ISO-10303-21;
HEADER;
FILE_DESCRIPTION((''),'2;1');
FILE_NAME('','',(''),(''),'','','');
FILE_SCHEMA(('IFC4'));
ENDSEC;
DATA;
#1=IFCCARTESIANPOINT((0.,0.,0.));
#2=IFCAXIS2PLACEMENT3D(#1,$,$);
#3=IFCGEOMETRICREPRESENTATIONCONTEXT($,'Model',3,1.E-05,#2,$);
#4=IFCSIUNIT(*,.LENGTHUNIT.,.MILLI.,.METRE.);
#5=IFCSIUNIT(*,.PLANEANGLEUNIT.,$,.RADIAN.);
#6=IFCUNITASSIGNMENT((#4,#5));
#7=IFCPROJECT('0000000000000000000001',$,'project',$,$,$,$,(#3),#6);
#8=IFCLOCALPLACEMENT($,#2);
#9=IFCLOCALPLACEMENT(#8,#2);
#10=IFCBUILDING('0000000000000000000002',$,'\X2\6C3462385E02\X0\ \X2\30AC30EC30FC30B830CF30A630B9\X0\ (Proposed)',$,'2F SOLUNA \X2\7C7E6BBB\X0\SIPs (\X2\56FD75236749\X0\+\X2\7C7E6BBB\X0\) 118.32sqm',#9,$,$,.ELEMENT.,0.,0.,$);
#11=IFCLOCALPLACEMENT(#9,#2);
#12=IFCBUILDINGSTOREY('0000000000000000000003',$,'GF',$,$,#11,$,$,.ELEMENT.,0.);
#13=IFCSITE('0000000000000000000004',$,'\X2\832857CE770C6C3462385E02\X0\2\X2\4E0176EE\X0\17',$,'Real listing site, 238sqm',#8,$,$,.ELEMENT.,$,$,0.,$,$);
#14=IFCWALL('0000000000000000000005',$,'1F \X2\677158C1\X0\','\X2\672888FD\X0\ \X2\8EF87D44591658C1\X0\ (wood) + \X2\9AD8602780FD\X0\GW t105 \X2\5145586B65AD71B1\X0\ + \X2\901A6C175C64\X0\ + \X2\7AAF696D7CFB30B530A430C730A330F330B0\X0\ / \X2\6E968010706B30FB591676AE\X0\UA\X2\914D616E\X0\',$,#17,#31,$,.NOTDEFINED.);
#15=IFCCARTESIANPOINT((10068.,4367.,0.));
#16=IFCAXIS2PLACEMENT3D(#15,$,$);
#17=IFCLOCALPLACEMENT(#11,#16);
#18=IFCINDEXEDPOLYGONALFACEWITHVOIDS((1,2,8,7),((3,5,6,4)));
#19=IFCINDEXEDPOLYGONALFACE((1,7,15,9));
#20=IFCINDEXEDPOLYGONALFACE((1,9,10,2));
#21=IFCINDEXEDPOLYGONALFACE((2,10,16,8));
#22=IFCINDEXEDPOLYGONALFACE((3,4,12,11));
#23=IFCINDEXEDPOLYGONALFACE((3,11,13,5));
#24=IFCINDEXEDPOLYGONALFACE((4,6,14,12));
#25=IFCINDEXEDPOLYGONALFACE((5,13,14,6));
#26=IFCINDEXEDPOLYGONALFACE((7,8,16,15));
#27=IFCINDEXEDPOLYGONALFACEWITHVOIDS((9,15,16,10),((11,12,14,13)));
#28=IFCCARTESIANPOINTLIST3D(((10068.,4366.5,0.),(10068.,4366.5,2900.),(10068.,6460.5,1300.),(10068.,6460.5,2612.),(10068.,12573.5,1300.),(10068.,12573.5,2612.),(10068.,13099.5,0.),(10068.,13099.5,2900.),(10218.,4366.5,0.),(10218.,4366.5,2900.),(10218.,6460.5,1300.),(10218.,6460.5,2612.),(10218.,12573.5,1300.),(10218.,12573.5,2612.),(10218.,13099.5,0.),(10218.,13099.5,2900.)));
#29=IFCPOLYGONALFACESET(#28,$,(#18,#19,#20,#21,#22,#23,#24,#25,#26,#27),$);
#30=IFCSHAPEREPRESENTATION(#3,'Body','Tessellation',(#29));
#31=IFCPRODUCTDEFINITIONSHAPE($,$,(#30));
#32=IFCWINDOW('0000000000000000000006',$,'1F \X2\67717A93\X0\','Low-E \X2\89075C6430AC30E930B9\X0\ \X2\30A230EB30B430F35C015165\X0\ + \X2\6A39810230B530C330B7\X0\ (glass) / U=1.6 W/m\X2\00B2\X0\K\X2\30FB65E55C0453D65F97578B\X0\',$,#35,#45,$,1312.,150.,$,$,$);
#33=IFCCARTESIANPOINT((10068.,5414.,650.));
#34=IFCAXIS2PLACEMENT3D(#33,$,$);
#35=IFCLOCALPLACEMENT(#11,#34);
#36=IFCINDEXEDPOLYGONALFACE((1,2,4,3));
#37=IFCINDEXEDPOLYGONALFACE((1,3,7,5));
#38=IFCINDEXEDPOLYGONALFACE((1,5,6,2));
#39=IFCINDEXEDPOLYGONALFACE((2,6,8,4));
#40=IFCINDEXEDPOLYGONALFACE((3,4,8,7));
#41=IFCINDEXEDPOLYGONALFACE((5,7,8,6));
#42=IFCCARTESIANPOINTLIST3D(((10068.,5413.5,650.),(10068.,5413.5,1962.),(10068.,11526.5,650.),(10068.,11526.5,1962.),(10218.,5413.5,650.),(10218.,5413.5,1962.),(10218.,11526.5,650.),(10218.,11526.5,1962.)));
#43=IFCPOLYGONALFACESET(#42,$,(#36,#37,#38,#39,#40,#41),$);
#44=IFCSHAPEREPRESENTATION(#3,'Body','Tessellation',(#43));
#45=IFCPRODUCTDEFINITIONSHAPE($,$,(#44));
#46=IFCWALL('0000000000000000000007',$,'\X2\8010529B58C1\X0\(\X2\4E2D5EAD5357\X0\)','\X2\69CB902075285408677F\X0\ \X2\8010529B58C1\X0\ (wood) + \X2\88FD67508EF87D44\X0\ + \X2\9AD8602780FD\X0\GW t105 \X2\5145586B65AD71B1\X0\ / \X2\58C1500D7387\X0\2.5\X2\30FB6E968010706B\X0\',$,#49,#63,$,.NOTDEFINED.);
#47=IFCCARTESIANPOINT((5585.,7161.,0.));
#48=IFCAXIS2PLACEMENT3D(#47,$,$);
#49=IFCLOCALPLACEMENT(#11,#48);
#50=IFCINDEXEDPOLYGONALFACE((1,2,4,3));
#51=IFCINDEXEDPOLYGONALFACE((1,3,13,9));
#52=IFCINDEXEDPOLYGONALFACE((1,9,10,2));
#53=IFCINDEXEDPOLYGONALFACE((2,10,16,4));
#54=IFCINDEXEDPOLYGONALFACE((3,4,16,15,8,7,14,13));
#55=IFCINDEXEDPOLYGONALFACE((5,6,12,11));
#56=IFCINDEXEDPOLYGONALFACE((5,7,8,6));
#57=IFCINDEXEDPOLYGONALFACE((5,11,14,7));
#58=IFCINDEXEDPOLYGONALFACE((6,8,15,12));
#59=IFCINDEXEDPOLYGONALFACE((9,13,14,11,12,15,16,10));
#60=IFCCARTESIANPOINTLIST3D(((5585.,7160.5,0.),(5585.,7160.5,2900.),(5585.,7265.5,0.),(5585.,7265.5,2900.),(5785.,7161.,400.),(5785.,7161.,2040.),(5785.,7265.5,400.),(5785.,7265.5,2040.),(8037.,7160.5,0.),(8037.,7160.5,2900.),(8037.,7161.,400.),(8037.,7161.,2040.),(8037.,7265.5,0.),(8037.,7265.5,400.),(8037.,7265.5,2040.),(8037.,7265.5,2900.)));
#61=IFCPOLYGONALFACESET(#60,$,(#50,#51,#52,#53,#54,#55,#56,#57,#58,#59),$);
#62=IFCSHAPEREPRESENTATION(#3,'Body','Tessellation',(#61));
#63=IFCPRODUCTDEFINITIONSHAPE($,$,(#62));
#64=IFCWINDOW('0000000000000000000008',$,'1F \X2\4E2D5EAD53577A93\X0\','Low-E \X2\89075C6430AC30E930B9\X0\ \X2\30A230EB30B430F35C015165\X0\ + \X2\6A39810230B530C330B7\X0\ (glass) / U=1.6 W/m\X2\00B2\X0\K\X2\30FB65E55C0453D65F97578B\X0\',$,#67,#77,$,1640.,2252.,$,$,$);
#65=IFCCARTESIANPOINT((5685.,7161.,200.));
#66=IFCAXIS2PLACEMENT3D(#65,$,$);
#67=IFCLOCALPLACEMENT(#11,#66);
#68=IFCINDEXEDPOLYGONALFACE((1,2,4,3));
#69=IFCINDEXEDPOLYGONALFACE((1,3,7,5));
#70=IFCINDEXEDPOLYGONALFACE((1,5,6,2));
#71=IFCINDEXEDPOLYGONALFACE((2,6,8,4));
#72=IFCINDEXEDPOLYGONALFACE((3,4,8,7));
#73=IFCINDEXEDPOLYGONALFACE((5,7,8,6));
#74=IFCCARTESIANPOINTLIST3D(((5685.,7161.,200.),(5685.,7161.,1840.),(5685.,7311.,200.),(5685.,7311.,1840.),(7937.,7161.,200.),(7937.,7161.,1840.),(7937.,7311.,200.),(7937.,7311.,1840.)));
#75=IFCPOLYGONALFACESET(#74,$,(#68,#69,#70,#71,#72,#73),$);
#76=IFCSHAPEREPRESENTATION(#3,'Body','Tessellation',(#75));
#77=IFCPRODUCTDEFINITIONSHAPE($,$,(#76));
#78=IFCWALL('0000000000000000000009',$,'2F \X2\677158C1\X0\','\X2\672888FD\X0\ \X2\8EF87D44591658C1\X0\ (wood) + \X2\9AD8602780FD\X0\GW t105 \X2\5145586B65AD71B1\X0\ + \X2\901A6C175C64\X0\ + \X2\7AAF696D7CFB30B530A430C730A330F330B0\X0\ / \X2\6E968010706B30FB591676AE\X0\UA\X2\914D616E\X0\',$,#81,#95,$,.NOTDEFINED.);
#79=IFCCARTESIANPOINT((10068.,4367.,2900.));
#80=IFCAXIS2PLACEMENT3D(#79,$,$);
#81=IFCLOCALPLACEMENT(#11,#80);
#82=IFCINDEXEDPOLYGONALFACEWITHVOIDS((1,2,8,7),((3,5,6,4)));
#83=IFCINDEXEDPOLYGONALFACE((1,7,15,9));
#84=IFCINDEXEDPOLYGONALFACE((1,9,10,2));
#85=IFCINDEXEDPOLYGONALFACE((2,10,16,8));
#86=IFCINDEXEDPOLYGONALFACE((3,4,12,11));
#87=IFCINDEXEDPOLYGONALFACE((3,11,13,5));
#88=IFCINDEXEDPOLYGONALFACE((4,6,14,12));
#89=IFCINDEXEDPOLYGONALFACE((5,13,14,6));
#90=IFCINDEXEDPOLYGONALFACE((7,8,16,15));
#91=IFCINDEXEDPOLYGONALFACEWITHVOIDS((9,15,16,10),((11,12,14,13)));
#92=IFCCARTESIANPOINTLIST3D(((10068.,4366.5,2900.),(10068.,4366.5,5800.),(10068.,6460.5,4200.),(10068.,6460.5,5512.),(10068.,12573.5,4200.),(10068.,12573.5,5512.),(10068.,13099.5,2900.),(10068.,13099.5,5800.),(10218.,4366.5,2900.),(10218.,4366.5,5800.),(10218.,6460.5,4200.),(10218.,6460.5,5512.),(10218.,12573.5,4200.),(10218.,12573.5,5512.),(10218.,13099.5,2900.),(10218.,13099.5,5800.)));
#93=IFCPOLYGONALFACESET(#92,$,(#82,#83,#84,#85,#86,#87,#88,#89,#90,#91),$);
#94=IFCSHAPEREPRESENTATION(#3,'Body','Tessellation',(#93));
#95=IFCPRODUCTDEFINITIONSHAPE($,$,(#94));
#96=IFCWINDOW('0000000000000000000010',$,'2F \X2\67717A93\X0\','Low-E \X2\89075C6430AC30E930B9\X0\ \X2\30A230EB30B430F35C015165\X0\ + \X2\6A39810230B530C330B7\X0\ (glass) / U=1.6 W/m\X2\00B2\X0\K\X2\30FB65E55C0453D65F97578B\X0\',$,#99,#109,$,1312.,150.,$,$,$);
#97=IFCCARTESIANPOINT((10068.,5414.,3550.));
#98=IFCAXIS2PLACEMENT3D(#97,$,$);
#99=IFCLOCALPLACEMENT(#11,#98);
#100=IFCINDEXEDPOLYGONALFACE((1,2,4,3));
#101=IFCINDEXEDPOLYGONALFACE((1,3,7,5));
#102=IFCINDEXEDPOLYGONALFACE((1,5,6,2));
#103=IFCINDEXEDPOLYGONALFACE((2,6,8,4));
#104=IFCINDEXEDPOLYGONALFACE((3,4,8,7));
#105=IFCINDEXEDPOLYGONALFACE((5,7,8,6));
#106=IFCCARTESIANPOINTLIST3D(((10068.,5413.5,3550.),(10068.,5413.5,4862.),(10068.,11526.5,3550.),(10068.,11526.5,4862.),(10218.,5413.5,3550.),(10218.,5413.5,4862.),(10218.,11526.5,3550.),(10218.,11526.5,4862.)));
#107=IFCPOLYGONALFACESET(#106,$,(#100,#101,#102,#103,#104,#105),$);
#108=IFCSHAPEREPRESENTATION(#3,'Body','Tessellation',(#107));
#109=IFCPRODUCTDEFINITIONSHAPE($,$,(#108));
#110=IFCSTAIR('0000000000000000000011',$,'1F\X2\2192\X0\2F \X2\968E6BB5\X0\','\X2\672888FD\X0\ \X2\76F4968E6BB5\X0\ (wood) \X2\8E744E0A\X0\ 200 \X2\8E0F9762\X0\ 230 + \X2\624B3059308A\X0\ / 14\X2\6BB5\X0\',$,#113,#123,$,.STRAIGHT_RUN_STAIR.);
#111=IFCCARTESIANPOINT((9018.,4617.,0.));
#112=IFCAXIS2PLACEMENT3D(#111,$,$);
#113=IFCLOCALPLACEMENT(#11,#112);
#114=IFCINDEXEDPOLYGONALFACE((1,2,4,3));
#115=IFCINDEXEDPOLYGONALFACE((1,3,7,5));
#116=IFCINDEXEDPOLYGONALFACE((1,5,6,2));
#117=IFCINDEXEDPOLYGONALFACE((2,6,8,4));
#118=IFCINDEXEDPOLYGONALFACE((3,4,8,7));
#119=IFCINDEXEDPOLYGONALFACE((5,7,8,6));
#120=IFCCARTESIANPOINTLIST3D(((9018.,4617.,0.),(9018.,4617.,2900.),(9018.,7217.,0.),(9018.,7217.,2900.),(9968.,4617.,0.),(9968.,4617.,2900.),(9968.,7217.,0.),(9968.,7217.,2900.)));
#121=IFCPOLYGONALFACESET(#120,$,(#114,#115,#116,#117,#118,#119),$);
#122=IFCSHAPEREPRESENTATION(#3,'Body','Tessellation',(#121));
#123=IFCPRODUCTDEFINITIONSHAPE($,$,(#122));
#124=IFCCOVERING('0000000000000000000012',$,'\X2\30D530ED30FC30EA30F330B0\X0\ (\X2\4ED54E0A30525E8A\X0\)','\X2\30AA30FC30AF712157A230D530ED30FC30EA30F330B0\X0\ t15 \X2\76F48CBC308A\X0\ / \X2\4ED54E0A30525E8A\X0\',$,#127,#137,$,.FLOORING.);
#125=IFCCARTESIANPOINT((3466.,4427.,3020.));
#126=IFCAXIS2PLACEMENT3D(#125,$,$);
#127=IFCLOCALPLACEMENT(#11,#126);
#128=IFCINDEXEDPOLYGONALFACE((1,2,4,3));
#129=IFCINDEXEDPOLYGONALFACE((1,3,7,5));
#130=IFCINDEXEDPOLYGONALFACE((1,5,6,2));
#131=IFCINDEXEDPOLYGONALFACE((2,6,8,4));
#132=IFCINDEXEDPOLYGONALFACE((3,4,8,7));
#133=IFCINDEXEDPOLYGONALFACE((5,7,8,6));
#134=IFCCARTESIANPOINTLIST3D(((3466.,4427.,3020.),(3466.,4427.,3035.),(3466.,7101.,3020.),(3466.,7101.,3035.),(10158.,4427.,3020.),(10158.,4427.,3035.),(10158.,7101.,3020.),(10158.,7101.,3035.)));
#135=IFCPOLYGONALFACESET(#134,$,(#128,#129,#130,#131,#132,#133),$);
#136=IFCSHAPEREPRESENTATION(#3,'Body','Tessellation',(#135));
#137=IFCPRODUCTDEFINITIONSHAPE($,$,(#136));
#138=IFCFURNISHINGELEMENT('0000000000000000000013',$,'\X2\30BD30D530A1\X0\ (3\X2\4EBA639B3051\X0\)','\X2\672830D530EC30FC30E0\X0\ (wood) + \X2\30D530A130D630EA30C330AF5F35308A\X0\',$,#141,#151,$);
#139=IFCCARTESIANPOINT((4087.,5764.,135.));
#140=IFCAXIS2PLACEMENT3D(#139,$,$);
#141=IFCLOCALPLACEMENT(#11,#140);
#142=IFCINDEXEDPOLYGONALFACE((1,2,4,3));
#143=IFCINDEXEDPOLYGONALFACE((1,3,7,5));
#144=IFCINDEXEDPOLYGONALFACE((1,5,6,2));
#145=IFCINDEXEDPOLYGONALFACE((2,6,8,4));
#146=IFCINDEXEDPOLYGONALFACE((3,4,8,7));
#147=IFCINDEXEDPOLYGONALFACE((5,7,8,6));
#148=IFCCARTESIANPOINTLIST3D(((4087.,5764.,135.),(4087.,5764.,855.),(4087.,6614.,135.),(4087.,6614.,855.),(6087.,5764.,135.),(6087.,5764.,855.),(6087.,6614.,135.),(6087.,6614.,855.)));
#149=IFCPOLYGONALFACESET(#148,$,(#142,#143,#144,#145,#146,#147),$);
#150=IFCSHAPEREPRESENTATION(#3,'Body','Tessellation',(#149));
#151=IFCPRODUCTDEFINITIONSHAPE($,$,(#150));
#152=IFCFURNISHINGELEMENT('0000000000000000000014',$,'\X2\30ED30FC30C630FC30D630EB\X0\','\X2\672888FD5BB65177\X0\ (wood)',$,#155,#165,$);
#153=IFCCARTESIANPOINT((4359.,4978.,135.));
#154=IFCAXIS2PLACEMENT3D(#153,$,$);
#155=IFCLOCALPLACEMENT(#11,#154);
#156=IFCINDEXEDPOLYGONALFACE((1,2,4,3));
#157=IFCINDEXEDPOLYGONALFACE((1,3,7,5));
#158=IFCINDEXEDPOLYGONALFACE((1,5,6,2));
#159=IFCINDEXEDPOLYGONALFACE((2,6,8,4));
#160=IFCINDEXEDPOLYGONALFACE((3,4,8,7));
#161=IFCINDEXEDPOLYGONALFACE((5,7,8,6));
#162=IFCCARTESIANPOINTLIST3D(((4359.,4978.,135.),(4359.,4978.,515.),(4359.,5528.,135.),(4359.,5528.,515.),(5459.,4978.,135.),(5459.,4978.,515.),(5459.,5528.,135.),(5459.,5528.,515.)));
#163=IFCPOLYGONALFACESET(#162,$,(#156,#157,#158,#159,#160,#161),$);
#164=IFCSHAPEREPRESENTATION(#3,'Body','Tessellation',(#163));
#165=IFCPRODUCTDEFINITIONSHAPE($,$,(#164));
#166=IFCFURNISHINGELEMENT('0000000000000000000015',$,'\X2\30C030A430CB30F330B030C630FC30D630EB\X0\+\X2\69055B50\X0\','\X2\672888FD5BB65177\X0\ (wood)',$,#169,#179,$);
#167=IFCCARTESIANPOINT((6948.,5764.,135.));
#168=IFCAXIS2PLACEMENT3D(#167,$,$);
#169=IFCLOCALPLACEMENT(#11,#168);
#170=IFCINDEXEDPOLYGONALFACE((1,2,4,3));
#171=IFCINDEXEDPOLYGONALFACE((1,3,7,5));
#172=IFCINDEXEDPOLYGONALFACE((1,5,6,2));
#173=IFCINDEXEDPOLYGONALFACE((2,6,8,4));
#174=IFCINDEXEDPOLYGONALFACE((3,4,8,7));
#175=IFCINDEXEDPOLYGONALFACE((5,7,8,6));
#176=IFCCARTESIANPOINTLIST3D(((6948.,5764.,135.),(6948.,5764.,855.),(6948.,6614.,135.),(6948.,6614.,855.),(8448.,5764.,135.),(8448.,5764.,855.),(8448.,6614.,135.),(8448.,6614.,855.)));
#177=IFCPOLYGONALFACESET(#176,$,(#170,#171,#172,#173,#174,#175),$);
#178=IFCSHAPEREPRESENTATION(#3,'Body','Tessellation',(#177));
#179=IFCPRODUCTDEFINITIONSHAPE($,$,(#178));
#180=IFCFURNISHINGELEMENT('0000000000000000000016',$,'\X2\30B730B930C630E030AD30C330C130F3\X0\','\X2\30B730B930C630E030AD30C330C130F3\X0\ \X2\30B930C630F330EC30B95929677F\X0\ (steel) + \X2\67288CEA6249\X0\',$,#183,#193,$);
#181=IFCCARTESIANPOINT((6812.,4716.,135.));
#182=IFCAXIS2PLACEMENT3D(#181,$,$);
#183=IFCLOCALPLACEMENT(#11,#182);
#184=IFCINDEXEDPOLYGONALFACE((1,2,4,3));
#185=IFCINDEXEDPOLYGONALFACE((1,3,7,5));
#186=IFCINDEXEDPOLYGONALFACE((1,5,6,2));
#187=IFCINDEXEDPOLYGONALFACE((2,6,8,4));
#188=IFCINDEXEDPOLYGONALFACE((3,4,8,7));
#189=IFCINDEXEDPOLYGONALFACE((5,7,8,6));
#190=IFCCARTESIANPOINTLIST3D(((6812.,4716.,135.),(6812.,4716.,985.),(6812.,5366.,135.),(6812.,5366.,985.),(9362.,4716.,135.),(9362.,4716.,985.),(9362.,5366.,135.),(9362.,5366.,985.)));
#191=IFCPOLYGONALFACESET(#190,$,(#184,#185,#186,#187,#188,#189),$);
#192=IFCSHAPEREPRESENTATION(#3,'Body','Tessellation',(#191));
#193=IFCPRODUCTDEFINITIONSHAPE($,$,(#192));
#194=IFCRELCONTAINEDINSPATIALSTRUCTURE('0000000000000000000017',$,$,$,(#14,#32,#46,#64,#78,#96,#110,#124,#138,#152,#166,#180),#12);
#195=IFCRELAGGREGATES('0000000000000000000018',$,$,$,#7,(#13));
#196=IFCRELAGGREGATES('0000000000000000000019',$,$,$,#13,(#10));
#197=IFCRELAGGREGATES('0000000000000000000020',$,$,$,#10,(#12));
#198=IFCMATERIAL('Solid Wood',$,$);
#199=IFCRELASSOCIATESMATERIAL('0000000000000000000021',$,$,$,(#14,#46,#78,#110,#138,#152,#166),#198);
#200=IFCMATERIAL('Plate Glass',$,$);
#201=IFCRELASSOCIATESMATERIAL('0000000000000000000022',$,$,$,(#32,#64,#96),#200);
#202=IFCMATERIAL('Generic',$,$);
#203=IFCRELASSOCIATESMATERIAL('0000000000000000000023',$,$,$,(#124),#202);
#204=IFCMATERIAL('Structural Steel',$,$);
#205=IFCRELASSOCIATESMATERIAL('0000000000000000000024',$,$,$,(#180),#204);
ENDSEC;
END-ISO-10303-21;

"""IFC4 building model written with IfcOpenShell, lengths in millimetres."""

from ifc_helpers import new_model, si_unit, frame, frame_2d, origin, place, context, project, spatial, rectangle, extrude, material, element, fill, save


model = new_model("IFC4")

# Units and contexts
model_context = context("Model", 3, precision=1e-05, world=origin())
ifc_project = project(units=[si_unit("LENGTHUNIT", "METRE", prefix="MILLI"), si_unit("PLANEANGLEUNIT", "RADIAN")], contexts=[model_context])

# Site, building, storey
site_placement = place(None, origin())
site = spatial("IfcSite", under=ifc_project, at=site_placement, Name="茨城県水戸市2丁目17", ObjectType="Real listing site, 238sqm", CompositionType="ELEMENT", RefElevation=0.0)
building_placement = place(site_placement, origin())
building = spatial("IfcBuilding", under=site, at=building_placement, Name="水戸市 ガレージハウス (Proposed)", ObjectType="2F SOLUNA 籾殻SIPs (国産杉+籾殻) 118.32sqm", CompositionType="ELEMENT", ElevationOfRefHeight=0.0, ElevationOfTerrain=0.0)
storey_placement = place(building_placement, origin())
storey = spatial("IfcBuildingStorey", under=building, at=storey_placement, Name="GF", CompositionType="ELEMENT", Elevation=0.0)

# Shared definitions
ifc_material_1 = material(Name="Solid Wood")

# Walls, openings, windows
wall_1_placement = place(storey_placement, frame((10068.0, 4367.0, 0.0)))
wall_1 = element("IfcWall", 1, at=wall_1_placement, inside=storey, material=ifc_material_1, Name="1F 東壁", Description="木製 軸組外壁 (wood) + 高性能GW t105 充填断熱 + 通気層 + 窯業系サイディング / 準耐火・外皮UA配慮", PredefinedType="NOTDEFINED", context=model_context, shape_type="SweptSolid", body=[
    extrude(rectangle(XDim=150.0, YDim=8733.0, at=frame_2d((75.0, 4366.0))), frame((10068.0, 4367.0, 0.0)), (0.0, 0.0, 1.0), 2900.0),
])
opening_1_placement = place(storey_placement, frame((10068.0, 5414.0, 650.0)))
opening_1 = element("IfcOpeningElement", 2, at=opening_1_placement, cuts=wall_1, PredefinedType="NOTDEFINED", context=model_context, shape_type="SweptSolid", body=[
    extrude(rectangle(XDim=150.0, YDim=6113.0, at=frame_2d((75.0, 3056.0))), frame((10068.0, 5414.0, 650.0)), (0.0, 0.0, 1.0), 1312.0),
])
ifc_material_2 = material(Name="Plate Glass")
window_1_placement = place(storey_placement, frame((10068.0, 5414.0, 650.0)))
window_1 = element("IfcWindow", 3, at=window_1_placement, inside=storey, material=ifc_material_2, Name="1F 東窓", Description="Low-E 複層ガラス アルゴン封入 + 樹脂サッシ (glass) / U=1.6 W/m²K・日射取得型", OverallHeight=1312.0, OverallWidth=150.0, context=model_context, shape_type="SweptSolid", body=[
    extrude(rectangle(XDim=150.0, YDim=6113.0, at=frame_2d((75.0, 3056.0))), frame((10068.0, 5414.0, 650.0)), (0.0, 0.0, 1.0), 1312.0),
])
fill(opening_1, window_1)
wall_2_placement = place(storey_placement, frame((5585.0, 7161.0, 0.0)))
wall_2 = element("IfcWall", 4, at=wall_2_placement, inside=storey, material=ifc_material_1, Name="耐力壁(中庭南)", Description="構造用合板 耐力壁 (wood) + 製材軸組 + 高性能GW t105 充填断熱 / 壁倍率2.5・準耐火", PredefinedType="NOTDEFINED", context=model_context, shape_type="SweptSolid", body=[
    extrude(rectangle(XDim=2452.0, YDim=105.0, at=frame_2d((1226.0, 52.0))), frame((5585.0, 7161.0, 0.0)), (0.0, 0.0, 1.0), 2900.0),
])
opening_2_placement = place(storey_placement, frame((5685.0, 7161.0, 200.0)))
opening_2 = element("IfcOpeningElement", 5, at=opening_2_placement, cuts=wall_2, PredefinedType="NOTDEFINED", context=model_context, shape_type="SweptSolid", body=[
    extrude(rectangle(XDim=2252.0, YDim=150.0, at=frame_2d((1126.0, 75.0))), frame((5685.0, 7161.0, 200.0)), (0.0, 0.0, 1.0), 1640.0),
])
window_2_placement = place(storey_placement, frame((5685.0, 7161.0, 200.0)))
window_2 = element("IfcWindow", 6, at=window_2_placement, inside=storey, material=ifc_material_2, Name="1F 中庭南窓", Description="Low-E 複層ガラス アルゴン封入 + 樹脂サッシ (glass) / U=1.6 W/m²K・日射取得型", OverallHeight=1640.0, OverallWidth=2252.0, context=model_context, shape_type="SweptSolid", body=[
    extrude(rectangle(XDim=2252.0, YDim=150.0, at=frame_2d((1126.0, 75.0))), frame((5685.0, 7161.0, 200.0)), (0.0, 0.0, 1.0), 1640.0),
])
fill(opening_2, window_2)

# Wall, opening, window
wall_3_placement = place(storey_placement, frame((10068.0, 4367.0, 2900.0)))
wall_3 = element("IfcWall", 7, at=wall_3_placement, inside=storey, material=ifc_material_1, Name="2F 東壁", Description="木製 軸組外壁 (wood) + 高性能GW t105 充填断熱 + 通気層 + 窯業系サイディング / 準耐火・外皮UA配慮", PredefinedType="NOTDEFINED", context=model_context, shape_type="SweptSolid", body=[
    extrude(rectangle(XDim=150.0, YDim=8733.0, at=frame_2d((75.0, 4366.0))), frame((10068.0, 4367.0, 2900.0)), (0.0, 0.0, 1.0), 2900.0),
])
opening_3_placement = place(storey_placement, frame((10068.0, 5414.0, 3550.0)))
opening_3 = element("IfcOpeningElement", 8, at=opening_3_placement, cuts=wall_3, PredefinedType="NOTDEFINED", context=model_context, shape_type="SweptSolid", body=[
    extrude(rectangle(XDim=150.0, YDim=6113.0, at=frame_2d((75.0, 3056.0))), frame((10068.0, 5414.0, 3550.0)), (0.0, 0.0, 1.0), 1312.0),
])
window_3_placement = place(storey_placement, frame((10068.0, 5414.0, 3550.0)))
window_3 = element("IfcWindow", 9, at=window_3_placement, inside=storey, material=ifc_material_2, Name="2F 東窓", Description="Low-E 複層ガラス アルゴン封入 + 樹脂サッシ (glass) / U=1.6 W/m²K・日射取得型", OverallHeight=1312.0, OverallWidth=150.0, context=model_context, shape_type="SweptSolid", body=[
    extrude(rectangle(XDim=150.0, YDim=6113.0, at=frame_2d((75.0, 3056.0))), frame((10068.0, 5414.0, 3550.0)), (0.0, 0.0, 1.0), 1312.0),
])
fill(opening_3, window_3)

# Stair
stair_placement = place(storey_placement, frame((9018.0, 4617.0, 0.0)))
element("IfcStair", 10, at=stair_placement, inside=storey, material=ifc_material_1, Name="1F→2F 階段", Description="木製 直階段 (wood) 蹴上 200 踏面 230 + 手すり / 14段", PredefinedType="STRAIGHT_RUN_STAIR", context=model_context, shape_type="SweptSolid", body=[
    extrude(rectangle(XDim=950.0, YDim=2600.0, at=frame_2d((475.0, 1300.0))), frame((9018.0, 4617.0, 0.0)), (0.0, 0.0, 1.0), 2900.0),
])

# Covering
ifc_material_3 = material(Name="Generic")
covering_placement = place(storey_placement, frame((3466.0, 4427.0, 3020.0)))
element("IfcCovering", 11, at=covering_placement, inside=storey, material=ifc_material_3, Name="フローリング (仕上げ床)", Description="オーク無垢フローリング t15 直貼り / 仕上げ床", PredefinedType="FLOORING", context=model_context, shape_type="SweptSolid", body=[
    extrude(rectangle(XDim=6692.0, YDim=2674.0, at=frame_2d((3346.0, 1337.0))), frame((3466.0, 4427.0, 3020.0)), (0.0, 0.0, 1.0), 15.0),
])

# Furnishing elements
furnishing_1_placement = place(storey_placement, frame((4087.0, 5764.0, 135.0)))
element("IfcFurnishingElement", 12, at=furnishing_1_placement, inside=storey, material=ifc_material_1, Name="ソファ (3人掛け)", Description="木フレーム (wood) + ファブリック張り", context=model_context, shape_type="SweptSolid", body=[
    extrude(rectangle(XDim=2000.0, YDim=850.0, at=frame_2d((1000.0, 425.0))), frame((4087.0, 5764.0, 135.0)), (0.0, 0.0, 1.0), 720.0),
])
furnishing_2_placement = place(storey_placement, frame((4359.0, 4978.0, 135.0)))
element("IfcFurnishingElement", 13, at=furnishing_2_placement, inside=storey, material=ifc_material_1, Name="ローテーブル", Description="木製家具 (wood)", context=model_context, shape_type="SweptSolid", body=[
    extrude(rectangle(XDim=1100.0, YDim=550.0, at=frame_2d((550.0, 275.0))), frame((4359.0, 4978.0, 135.0)), (0.0, 0.0, 1.0), 380.0),
])
furnishing_3_placement = place(storey_placement, frame((6948.0, 5764.0, 135.0)))
element("IfcFurnishingElement", 14, at=furnishing_3_placement, inside=storey, material=ifc_material_1, Name="ダイニングテーブル+椅子", Description="木製家具 (wood)", context=model_context, shape_type="SweptSolid", body=[
    extrude(rectangle(XDim=1500.0, YDim=850.0, at=frame_2d((750.0, 425.0))), frame((6948.0, 5764.0, 135.0)), (0.0, 0.0, 1.0), 720.0),
])
ifc_material_4 = material(Name="Structural Steel")
furnishing_4_placement = place(storey_placement, frame((6812.0, 4716.0, 135.0)))
element("IfcFurnishingElement", 15, at=furnishing_4_placement, inside=storey, material=ifc_material_4, Name="システムキッチン", Description="システムキッチン ステンレス天板 (steel) + 木質扉", context=model_context, shape_type="SweptSolid", body=[
    extrude(rectangle(XDim=2550.0, YDim=650.0, at=frame_2d((1275.0, 325.0))), frame((6812.0, 4716.0, 135.0)), (0.0, 0.0, 1.0), 850.0),
])

save(model, "model.ifc")
